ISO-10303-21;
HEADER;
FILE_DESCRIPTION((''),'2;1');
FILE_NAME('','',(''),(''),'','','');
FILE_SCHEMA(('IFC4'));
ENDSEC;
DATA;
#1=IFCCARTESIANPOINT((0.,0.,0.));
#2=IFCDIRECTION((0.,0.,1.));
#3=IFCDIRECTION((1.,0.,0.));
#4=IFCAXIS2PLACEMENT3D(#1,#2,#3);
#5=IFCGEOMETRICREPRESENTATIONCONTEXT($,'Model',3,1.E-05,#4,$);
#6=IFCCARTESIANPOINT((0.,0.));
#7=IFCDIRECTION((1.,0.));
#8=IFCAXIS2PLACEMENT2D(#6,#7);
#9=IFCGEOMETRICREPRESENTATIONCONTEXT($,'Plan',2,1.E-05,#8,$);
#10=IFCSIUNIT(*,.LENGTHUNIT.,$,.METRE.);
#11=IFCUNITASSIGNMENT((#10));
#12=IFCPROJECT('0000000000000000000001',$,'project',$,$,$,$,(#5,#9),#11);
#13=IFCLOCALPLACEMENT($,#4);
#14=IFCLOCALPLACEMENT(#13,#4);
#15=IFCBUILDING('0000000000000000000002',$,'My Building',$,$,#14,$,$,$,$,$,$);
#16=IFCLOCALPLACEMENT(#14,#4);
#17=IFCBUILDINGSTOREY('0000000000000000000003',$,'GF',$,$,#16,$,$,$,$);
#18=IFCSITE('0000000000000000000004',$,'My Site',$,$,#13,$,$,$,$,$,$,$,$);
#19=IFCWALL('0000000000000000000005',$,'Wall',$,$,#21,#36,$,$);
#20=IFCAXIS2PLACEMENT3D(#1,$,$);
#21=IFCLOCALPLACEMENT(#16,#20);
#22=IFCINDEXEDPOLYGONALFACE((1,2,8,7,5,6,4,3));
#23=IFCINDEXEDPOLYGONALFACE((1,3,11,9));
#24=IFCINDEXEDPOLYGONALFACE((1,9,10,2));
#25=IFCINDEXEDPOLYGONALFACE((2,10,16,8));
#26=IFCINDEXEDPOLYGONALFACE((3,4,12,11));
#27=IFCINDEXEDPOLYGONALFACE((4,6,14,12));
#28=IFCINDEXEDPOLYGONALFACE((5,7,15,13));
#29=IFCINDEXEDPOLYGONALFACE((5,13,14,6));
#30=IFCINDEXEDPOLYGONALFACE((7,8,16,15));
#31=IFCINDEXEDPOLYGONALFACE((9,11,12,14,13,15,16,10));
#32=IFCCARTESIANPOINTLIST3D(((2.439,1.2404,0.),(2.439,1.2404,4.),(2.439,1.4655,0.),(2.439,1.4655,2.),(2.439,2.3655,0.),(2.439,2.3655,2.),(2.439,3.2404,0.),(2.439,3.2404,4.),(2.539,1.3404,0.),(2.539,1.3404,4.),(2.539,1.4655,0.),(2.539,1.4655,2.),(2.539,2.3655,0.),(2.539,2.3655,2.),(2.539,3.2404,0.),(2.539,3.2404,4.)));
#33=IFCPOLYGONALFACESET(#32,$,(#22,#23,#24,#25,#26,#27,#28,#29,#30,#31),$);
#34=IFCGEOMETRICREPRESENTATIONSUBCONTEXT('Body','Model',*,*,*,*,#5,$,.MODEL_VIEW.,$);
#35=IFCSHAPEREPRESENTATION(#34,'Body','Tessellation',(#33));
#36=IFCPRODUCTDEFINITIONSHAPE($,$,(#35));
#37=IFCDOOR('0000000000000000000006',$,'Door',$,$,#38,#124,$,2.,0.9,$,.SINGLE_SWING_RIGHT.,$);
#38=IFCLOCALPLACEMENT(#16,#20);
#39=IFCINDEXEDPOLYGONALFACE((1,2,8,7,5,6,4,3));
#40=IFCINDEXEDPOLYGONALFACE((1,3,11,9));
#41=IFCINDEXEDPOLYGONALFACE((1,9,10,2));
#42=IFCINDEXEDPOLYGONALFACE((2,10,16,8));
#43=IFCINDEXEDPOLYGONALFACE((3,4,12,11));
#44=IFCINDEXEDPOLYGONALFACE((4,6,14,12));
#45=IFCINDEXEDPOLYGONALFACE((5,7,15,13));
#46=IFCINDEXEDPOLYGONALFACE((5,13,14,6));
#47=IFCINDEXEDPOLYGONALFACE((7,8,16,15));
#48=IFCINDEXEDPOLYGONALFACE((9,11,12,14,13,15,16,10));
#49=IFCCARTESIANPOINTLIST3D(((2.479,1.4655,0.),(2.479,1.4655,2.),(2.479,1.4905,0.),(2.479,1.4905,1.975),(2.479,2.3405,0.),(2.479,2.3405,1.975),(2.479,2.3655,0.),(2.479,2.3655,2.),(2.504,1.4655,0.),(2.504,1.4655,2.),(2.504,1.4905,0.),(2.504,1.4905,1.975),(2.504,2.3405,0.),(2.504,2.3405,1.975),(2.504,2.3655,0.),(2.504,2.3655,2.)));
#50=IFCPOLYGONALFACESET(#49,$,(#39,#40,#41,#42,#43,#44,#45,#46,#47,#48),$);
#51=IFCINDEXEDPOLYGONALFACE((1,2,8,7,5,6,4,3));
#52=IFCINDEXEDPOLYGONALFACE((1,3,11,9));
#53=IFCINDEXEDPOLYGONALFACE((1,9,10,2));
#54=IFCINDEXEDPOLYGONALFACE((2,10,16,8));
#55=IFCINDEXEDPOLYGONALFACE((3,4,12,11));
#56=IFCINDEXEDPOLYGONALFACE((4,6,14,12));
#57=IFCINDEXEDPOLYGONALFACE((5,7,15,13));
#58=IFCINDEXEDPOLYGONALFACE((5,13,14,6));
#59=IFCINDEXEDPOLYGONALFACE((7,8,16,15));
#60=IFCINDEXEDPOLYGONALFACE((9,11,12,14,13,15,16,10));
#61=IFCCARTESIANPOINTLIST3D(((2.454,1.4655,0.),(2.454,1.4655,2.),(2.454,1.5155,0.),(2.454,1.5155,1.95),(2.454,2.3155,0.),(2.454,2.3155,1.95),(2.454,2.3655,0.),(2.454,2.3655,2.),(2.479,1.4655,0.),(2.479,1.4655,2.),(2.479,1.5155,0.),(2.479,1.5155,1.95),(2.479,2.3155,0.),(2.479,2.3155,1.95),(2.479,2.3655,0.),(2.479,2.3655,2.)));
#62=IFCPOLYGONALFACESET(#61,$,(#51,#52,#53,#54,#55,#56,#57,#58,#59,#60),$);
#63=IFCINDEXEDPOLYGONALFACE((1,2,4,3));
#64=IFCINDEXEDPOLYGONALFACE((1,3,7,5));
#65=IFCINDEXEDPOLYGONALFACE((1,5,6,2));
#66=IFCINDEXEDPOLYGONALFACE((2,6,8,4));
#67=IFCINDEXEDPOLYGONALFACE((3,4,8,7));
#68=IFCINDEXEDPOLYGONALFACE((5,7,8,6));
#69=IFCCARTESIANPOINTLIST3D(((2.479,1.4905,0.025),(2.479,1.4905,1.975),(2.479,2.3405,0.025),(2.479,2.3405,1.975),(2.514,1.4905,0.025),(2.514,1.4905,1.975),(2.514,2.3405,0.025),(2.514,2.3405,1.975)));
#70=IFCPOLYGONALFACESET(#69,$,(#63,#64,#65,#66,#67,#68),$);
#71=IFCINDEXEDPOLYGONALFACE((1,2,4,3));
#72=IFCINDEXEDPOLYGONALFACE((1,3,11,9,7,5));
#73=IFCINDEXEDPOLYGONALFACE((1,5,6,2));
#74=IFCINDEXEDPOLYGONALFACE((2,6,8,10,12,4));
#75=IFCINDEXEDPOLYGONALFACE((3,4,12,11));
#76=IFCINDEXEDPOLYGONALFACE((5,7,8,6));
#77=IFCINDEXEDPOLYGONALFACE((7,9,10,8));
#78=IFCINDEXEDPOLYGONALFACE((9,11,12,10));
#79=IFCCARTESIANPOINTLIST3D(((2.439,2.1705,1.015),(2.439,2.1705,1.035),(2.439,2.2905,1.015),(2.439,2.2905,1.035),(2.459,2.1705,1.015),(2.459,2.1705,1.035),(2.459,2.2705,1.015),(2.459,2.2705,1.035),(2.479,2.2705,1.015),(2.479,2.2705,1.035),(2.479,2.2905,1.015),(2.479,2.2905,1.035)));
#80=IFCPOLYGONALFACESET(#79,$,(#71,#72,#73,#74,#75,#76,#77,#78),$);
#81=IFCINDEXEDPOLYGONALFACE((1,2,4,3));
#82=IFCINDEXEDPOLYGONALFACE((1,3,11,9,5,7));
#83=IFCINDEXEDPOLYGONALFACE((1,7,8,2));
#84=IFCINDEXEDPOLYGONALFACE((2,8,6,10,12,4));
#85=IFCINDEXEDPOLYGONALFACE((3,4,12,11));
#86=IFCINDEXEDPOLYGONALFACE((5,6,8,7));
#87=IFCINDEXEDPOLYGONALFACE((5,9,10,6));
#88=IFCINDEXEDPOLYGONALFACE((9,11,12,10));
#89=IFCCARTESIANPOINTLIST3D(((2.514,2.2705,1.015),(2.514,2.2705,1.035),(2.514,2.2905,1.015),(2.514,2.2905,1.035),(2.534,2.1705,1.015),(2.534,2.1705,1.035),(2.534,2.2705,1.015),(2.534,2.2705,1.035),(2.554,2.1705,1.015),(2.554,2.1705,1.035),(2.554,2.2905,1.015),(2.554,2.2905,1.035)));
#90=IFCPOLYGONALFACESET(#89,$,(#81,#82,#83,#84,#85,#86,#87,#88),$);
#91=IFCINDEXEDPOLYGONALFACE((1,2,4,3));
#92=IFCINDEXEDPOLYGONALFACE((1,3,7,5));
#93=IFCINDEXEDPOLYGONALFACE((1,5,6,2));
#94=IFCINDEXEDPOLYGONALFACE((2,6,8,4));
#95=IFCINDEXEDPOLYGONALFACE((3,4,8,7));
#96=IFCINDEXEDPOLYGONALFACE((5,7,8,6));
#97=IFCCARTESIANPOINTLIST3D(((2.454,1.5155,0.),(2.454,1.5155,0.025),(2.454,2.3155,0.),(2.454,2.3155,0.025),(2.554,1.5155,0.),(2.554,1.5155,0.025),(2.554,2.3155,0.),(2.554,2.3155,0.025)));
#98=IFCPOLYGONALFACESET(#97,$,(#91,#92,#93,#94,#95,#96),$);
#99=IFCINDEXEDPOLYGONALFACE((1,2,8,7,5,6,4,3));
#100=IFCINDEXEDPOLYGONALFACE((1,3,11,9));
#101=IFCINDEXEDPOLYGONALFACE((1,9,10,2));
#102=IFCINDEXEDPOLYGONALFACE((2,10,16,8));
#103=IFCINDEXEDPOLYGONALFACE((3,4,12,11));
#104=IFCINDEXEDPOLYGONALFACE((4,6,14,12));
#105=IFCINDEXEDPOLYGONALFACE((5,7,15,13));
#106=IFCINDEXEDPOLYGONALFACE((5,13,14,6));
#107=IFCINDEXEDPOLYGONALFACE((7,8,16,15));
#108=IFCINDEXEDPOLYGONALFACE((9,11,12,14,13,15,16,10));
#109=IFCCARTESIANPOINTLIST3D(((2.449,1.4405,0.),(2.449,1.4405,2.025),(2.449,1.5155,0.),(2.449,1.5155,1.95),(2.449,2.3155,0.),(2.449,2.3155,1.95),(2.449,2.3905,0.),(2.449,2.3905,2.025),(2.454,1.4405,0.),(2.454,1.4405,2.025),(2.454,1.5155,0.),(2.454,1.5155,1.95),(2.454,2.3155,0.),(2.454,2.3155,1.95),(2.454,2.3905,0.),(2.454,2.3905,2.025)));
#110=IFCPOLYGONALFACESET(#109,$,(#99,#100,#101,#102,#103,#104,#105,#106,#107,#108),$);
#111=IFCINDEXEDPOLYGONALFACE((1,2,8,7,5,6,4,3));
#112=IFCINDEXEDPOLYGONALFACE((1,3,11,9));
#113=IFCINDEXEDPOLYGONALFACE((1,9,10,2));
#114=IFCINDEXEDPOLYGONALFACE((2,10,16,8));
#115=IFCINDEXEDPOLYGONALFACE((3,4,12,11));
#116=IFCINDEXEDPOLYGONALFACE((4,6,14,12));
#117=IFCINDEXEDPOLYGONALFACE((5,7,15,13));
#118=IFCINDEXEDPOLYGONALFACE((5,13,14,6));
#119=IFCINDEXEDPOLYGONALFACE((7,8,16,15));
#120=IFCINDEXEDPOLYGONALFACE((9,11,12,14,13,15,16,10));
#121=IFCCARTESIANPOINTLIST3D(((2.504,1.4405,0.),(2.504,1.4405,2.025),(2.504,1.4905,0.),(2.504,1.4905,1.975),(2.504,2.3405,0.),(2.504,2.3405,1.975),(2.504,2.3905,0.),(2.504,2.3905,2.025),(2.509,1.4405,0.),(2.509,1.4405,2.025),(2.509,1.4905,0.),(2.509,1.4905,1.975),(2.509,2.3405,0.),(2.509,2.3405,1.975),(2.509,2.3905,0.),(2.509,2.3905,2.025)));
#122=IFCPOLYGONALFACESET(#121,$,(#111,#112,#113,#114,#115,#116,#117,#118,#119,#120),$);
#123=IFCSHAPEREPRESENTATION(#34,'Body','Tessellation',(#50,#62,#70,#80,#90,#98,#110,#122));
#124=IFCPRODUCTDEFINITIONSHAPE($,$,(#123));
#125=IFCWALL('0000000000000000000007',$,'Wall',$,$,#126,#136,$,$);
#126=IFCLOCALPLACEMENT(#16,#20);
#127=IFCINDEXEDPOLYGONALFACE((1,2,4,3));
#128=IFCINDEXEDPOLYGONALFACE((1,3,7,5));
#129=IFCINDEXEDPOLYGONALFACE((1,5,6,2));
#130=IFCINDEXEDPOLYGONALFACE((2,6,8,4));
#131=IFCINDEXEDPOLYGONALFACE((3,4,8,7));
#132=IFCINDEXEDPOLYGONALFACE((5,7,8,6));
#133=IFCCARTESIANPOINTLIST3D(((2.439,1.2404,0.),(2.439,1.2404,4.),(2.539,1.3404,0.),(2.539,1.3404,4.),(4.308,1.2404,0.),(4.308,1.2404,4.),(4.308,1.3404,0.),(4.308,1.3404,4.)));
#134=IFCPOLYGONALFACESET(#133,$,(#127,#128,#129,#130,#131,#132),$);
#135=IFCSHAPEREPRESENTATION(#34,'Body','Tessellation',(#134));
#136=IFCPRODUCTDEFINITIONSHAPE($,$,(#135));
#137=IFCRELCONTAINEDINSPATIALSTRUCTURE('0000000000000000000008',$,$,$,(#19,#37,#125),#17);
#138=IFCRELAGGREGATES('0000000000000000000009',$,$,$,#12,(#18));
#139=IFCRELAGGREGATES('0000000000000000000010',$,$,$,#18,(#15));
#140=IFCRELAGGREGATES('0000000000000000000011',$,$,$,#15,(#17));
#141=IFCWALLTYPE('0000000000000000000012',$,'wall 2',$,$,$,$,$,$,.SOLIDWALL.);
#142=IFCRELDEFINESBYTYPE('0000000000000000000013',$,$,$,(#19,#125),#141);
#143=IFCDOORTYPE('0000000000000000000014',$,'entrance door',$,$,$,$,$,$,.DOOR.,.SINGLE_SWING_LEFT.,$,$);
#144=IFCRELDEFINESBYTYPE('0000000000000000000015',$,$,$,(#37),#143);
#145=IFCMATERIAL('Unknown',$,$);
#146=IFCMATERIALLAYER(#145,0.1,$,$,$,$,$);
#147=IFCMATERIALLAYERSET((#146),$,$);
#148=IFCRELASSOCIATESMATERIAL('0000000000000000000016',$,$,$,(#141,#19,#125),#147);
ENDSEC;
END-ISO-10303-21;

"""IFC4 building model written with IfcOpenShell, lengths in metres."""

from ifc_helpers import new_model, entity, si_unit, frame, origin_with_axes, origin_2d_with_axis, place, context, subcontext, project, spatial, line, indexed_curve, outline, extrude, shape, source, transform, mapped, material, layer, layer_set, layer_usage, type_object, type_shapes, element, fill, save


model = new_model("IFC4")

# Units and contexts
model_context = context("Model", 3, precision=1e-05, world=origin_with_axes())
plan_context = context("Plan", 2, precision=1e-05, world=origin_2d_with_axis())
body_context_1 = subcontext(model_context, "Body", "Model", "MODEL_VIEW")
body_context_2 = subcontext(plan_context, "Body", "Plan", "PLAN_VIEW")
ifc_project = project(units=[si_unit("LENGTHUNIT", "METRE")], contexts=[model_context, plan_context])

# Site, building, storey
site_placement = place(None, origin_with_axes())
site = spatial("IfcSite", under=ifc_project, at=site_placement, Name="My Site")
building_placement = place(site_placement, origin_with_axes())
building = spatial("IfcBuilding", under=site, at=building_placement, Name="My Building")
storey_placement = place(building_placement, origin_with_axes())
storey = spatial("IfcBuildingStorey", under=building, at=storey_placement, Name="GF")

# Shared definitions
ifc_material = material(Name="Unknown")

# Shared definitions
shared_shape_1 = source(origin_with_axes(), body_context_1, "Body", "SweptSolid", [
    extrude(outline(indexed_curve([(0.0, 0.0), (0.9, 0.0), (0.9, 2.0), (0.0, 2.0)], segments=[line(1, 2, 3, 4, 1)])), frame((0.0, -0.6, 0.0), z_axis=(0.0, -1.0, 0.0), x_axis=(1.0, 0.0, 0.0)), (0.0, 0.0, -1.0), 1.2),
])
door_type = type_object("IfcDoorType", Name="entrance door", OperationType="SINGLE_SWING_LEFT", PredefinedType="DOOR")
shared_shape_2 = source(origin_with_axes(), body_context_1, "Body", "SweptSolid", [
    extrude(outline(indexed_curve([(0.0, 0.0), (0.0, 2.0), (0.9, 2.0), (0.9, 0.0), (0.875, 0.0), (0.875, 1.975), (0.025, 1.975), (0.025, 0.0)], segments=[line(1, 2, 3, 4, 5, 6, 7, 8, 1)])), frame((0.0, 0.025, 0.0), z_axis=(0.0, -1.0, 0.0), x_axis=(1.0, 0.0, 0.0)), (0.0, 0.0, -1.0), 0.025),
    extrude(outline(indexed_curve([(0.0, 0.0), (0.0, 2.0), (0.9, 2.0), (0.9, 0.0), (0.85, 0.0), (0.85, 1.95), (0.05, 1.95), (0.05, 0.0)], segments=[line(1, 2, 3, 4, 5, 6, 7, 8, 1)])), frame((0.0, 0.0, 0.0), z_axis=(0.0, -1.0, 0.0), x_axis=(1.0, 0.0, 0.0)), (0.0, 0.0, -1.0), 0.025),
    extrude(outline(indexed_curve([(0.0, 0.0), (0.85, 0.0), (0.85, 0.035), (0.0, 0.035)], segments=[line(1, 2, 3, 4, 1)])), frame((0.025, 0.025, 0.025), z_axis=(0.0, 0.0, 1.0), x_axis=(1.0, 0.0, 0.0)), (0.0, 0.0, 1.0), 1.95),
    extrude(outline(indexed_curve([(0.0, 0.0), (0.0, -0.04), (0.12, -0.04), (0.12, -0.02), (0.02, -0.02), (0.02, 0.0)], segments=[line(1, 2, 3, 4, 5, 6, 1)])), frame((0.075, 0.025, 1.015), z_axis=(0.0, 0.0, 1.0), x_axis=(1.0, 0.0, 0.0)), (0.0, 0.0, 1.0), 0.02),
    extrude(outline(indexed_curve([(0.0, 0.0), (0.0, 0.04), (0.12, 0.04), (0.12, 0.02), (0.02, 0.02), (0.02, 0.0)], segments=[line(1, 2, 3, 4, 5, 6, 1)])), frame((0.075, 0.06, 1.015), z_axis=(0.0, 0.0, 1.0), x_axis=(1.0, 0.0, 0.0)), (0.0, 0.0, 1.0), 0.02),
    extrude(outline(indexed_curve([(0.0, 0.0), (0.8, 0.0), (0.8, 0.1), (0.0, 0.1)], segments=[line(1, 2, 3, 4, 1)])), frame((0.05, 0.0, 0.0), z_axis=(0.0, 0.0, 1.0), x_axis=(1.0, 0.0, 0.0)), (0.0, 0.0, 1.0), 0.025),
    extrude(outline(indexed_curve([(0.0, 0.0), (0.0, 2.025), (0.95, 2.025), (0.95, 0.0), (0.875, 0.0), (0.875, 1.95), (0.075, 1.95), (0.075, 0.0)], segments=[line(1, 2, 3, 4, 5, 6, 7, 8, 1)])), frame((-0.025, -0.005, 0.0), z_axis=(0.0, -1.0, 0.0), x_axis=(1.0, 0.0, 0.0)), (0.0, 0.0, -1.0), 0.005),
    extrude(outline(indexed_curve([(0.0, 0.0), (0.0, 2.025), (0.95, 2.025), (0.95, 0.0), (0.9, 0.0), (0.9, 1.975), (0.05, 1.975), (0.05, 0.0)], segments=[line(1, 2, 3, 4, 5, 6, 7, 8, 1)])), frame((-0.025, 0.05, 0.0), z_axis=(0.0, -1.0, 0.0), x_axis=(1.0, 0.0, 0.0)), (0.0, 0.0, -1.0), 0.005),
])
shared_shape_3 = source(origin_with_axes(), body_context_2, "Body", "Curve2D", [
    entity("IfcIndexedPolyCurve", entity("IfcCartesianPointList2D", [[0.0, 0.0], [0.0, 0.05], [0.025, 0.05], [0.025, 0.025], [0.05, 0.025], [0.05, 0.0]]), [entity("IfcLineIndex", [1, 2, 3, 4, 5, 6, 1])]),
    entity("IfcIndexedPolyCurve", entity("IfcCartesianPointList2D", [[0.9, 0.0], [0.9, 0.05], [0.875, 0.05], [0.875, 0.025], [0.85, 0.025], [0.85, 0.0]]), [entity("IfcLineIndex", [1, 2, 3, 4, 5, 6, 1])]),
    entity("IfcTrimmedCurve", entity("IfcEllipse", entity("IfcAxis2Placement2D", entity("IfcCartesianPoint", [0.84, 0.05]), entity("IfcDirection", [1.0, 0.0])), 0.815, 0.85), [entity("IfcCartesianPoint", [0.84, 0.9])], [entity("IfcCartesianPoint", [0.025, 0.05])], True, "CARTESIAN"),
    entity("IfcIndexedPolyCurve", entity("IfcCartesianPointList2D", [[0.875, 0.05], [0.84, 0.05], [0.84, 0.9], [0.875, 0.9]]), [entity("IfcLineIndex", [1, 2, 3, 4, 1])]),
])
type_shapes(door_type, [shared_shape_2, shared_shape_3])

# Shared definitions
ifc_layer_1 = layer(ifc_material, 0.1)
ifc_layer_set_1 = layer_set([ifc_layer_1])
wall_type_1 = type_object("IfcWallType", Name="wall 2", PredefinedType="SOLIDWALL", material=ifc_layer_set_1)

# Wall, opening, door
ifc_layer_usage_1 = layer_usage(ifc_layer_set_1, "AXIS2", "POSITIVE", 0.0)
wall_1_placement = place(storey_placement, frame((2.439, 3.2404, 0.0), z_axis=(0.0, 0.0, 1.0), x_axis=(0.0, -1.0, 0.0)))
wall_1 = element("IfcWall", 1, at=wall_1_placement, inside=storey, type_object=wall_type_1, material=ifc_layer_usage_1, Name="Wall", context=body_context_1, shape_type="SweptSolid", body=[
    extrude(outline(indexed_curve([(0.0, 0.0), (0.0, 0.1), (1.9, 0.1), (2.0, 0.0)], segments=[line(1, 2, 3, 4, 1)])), origin_with_axes(), (0.0, 0.0, 1.0), 4.0),
])
opening_1_placement = place(wall_1_placement, frame((0.8749, 0.015, 0.0), z_axis=(0.0, 0.0, 1.0), x_axis=(1.0, 0.0, 0.0)))
opening_1 = element("IfcOpeningElement", 2, at=opening_1_placement, cuts=wall_1, PredefinedType="OPENING", context=body_context_1, shape_type="MappedRepresentation", body=[
    mapped(shared_shape_1, transform((0.0, 0.0, 0.0), x_axis=(1.0, 0.0, 0.0), y_axis=(0.0, 1.0, 0.0), z_axis=(0.0, 0.0, 1.0), scale=1.0)),
])
door_1_placement = place(opening_1_placement, frame((0.0, 0.0, 0.0), z_axis=(0.0, 0.0, 1.0), x_axis=(1.0, 0.0, 0.0)))
door_1 = element("IfcDoor", 3, at=door_1_placement, inside=storey, type_object=door_type, Name="Door", OperationType="SINGLE_SWING_RIGHT", OverallHeight=2.0, OverallWidth=0.9, shapes=[
    shape(body_context_1, "Body", "MappedRepresentation", [mapped(shared_shape_2, transform((0.0, 0.0, 0.0), x_axis=(1.0, 0.0, 0.0), y_axis=(0.0, 1.0, 0.0), z_axis=(0.0, 0.0, 1.0), scale=1.0))]),
    shape(body_context_2, "Body", "MappedRepresentation", [mapped(shared_shape_3, transform((0.0, 0.0, 0.0), x_axis=(1.0, 0.0, 0.0), y_axis=(0.0, 1.0, 0.0), z_axis=(0.0, 0.0, 1.0), scale=1.0))]),
])
fill(opening_1, door_1)

# Wall
ifc_layer_usage_2 = layer_usage(ifc_layer_set_1, "AXIS2", "POSITIVE", 0.0)
wall_2_placement = place(storey_placement, frame((2.439, 1.2404, 0.0), z_axis=(0.0, 0.0, 1.0), x_axis=(1.0, 0.0, 0.0)))
element("IfcWall", 4, at=wall_2_placement, inside=storey, type_object=wall_type_1, material=ifc_layer_usage_2, Name="Wall", context=body_context_1, shape_type="SweptSolid", body=[
    extrude(outline(indexed_curve([(0.0, 0.0), (0.1, 0.1), (1.8691, 0.1), (1.8691, 0.0)], segments=[line(1, 2, 3, 4, 1)])), origin_with_axes(), (0.0, 0.0, 1.0), 4.0),
])

save(model, "model.ifc")
